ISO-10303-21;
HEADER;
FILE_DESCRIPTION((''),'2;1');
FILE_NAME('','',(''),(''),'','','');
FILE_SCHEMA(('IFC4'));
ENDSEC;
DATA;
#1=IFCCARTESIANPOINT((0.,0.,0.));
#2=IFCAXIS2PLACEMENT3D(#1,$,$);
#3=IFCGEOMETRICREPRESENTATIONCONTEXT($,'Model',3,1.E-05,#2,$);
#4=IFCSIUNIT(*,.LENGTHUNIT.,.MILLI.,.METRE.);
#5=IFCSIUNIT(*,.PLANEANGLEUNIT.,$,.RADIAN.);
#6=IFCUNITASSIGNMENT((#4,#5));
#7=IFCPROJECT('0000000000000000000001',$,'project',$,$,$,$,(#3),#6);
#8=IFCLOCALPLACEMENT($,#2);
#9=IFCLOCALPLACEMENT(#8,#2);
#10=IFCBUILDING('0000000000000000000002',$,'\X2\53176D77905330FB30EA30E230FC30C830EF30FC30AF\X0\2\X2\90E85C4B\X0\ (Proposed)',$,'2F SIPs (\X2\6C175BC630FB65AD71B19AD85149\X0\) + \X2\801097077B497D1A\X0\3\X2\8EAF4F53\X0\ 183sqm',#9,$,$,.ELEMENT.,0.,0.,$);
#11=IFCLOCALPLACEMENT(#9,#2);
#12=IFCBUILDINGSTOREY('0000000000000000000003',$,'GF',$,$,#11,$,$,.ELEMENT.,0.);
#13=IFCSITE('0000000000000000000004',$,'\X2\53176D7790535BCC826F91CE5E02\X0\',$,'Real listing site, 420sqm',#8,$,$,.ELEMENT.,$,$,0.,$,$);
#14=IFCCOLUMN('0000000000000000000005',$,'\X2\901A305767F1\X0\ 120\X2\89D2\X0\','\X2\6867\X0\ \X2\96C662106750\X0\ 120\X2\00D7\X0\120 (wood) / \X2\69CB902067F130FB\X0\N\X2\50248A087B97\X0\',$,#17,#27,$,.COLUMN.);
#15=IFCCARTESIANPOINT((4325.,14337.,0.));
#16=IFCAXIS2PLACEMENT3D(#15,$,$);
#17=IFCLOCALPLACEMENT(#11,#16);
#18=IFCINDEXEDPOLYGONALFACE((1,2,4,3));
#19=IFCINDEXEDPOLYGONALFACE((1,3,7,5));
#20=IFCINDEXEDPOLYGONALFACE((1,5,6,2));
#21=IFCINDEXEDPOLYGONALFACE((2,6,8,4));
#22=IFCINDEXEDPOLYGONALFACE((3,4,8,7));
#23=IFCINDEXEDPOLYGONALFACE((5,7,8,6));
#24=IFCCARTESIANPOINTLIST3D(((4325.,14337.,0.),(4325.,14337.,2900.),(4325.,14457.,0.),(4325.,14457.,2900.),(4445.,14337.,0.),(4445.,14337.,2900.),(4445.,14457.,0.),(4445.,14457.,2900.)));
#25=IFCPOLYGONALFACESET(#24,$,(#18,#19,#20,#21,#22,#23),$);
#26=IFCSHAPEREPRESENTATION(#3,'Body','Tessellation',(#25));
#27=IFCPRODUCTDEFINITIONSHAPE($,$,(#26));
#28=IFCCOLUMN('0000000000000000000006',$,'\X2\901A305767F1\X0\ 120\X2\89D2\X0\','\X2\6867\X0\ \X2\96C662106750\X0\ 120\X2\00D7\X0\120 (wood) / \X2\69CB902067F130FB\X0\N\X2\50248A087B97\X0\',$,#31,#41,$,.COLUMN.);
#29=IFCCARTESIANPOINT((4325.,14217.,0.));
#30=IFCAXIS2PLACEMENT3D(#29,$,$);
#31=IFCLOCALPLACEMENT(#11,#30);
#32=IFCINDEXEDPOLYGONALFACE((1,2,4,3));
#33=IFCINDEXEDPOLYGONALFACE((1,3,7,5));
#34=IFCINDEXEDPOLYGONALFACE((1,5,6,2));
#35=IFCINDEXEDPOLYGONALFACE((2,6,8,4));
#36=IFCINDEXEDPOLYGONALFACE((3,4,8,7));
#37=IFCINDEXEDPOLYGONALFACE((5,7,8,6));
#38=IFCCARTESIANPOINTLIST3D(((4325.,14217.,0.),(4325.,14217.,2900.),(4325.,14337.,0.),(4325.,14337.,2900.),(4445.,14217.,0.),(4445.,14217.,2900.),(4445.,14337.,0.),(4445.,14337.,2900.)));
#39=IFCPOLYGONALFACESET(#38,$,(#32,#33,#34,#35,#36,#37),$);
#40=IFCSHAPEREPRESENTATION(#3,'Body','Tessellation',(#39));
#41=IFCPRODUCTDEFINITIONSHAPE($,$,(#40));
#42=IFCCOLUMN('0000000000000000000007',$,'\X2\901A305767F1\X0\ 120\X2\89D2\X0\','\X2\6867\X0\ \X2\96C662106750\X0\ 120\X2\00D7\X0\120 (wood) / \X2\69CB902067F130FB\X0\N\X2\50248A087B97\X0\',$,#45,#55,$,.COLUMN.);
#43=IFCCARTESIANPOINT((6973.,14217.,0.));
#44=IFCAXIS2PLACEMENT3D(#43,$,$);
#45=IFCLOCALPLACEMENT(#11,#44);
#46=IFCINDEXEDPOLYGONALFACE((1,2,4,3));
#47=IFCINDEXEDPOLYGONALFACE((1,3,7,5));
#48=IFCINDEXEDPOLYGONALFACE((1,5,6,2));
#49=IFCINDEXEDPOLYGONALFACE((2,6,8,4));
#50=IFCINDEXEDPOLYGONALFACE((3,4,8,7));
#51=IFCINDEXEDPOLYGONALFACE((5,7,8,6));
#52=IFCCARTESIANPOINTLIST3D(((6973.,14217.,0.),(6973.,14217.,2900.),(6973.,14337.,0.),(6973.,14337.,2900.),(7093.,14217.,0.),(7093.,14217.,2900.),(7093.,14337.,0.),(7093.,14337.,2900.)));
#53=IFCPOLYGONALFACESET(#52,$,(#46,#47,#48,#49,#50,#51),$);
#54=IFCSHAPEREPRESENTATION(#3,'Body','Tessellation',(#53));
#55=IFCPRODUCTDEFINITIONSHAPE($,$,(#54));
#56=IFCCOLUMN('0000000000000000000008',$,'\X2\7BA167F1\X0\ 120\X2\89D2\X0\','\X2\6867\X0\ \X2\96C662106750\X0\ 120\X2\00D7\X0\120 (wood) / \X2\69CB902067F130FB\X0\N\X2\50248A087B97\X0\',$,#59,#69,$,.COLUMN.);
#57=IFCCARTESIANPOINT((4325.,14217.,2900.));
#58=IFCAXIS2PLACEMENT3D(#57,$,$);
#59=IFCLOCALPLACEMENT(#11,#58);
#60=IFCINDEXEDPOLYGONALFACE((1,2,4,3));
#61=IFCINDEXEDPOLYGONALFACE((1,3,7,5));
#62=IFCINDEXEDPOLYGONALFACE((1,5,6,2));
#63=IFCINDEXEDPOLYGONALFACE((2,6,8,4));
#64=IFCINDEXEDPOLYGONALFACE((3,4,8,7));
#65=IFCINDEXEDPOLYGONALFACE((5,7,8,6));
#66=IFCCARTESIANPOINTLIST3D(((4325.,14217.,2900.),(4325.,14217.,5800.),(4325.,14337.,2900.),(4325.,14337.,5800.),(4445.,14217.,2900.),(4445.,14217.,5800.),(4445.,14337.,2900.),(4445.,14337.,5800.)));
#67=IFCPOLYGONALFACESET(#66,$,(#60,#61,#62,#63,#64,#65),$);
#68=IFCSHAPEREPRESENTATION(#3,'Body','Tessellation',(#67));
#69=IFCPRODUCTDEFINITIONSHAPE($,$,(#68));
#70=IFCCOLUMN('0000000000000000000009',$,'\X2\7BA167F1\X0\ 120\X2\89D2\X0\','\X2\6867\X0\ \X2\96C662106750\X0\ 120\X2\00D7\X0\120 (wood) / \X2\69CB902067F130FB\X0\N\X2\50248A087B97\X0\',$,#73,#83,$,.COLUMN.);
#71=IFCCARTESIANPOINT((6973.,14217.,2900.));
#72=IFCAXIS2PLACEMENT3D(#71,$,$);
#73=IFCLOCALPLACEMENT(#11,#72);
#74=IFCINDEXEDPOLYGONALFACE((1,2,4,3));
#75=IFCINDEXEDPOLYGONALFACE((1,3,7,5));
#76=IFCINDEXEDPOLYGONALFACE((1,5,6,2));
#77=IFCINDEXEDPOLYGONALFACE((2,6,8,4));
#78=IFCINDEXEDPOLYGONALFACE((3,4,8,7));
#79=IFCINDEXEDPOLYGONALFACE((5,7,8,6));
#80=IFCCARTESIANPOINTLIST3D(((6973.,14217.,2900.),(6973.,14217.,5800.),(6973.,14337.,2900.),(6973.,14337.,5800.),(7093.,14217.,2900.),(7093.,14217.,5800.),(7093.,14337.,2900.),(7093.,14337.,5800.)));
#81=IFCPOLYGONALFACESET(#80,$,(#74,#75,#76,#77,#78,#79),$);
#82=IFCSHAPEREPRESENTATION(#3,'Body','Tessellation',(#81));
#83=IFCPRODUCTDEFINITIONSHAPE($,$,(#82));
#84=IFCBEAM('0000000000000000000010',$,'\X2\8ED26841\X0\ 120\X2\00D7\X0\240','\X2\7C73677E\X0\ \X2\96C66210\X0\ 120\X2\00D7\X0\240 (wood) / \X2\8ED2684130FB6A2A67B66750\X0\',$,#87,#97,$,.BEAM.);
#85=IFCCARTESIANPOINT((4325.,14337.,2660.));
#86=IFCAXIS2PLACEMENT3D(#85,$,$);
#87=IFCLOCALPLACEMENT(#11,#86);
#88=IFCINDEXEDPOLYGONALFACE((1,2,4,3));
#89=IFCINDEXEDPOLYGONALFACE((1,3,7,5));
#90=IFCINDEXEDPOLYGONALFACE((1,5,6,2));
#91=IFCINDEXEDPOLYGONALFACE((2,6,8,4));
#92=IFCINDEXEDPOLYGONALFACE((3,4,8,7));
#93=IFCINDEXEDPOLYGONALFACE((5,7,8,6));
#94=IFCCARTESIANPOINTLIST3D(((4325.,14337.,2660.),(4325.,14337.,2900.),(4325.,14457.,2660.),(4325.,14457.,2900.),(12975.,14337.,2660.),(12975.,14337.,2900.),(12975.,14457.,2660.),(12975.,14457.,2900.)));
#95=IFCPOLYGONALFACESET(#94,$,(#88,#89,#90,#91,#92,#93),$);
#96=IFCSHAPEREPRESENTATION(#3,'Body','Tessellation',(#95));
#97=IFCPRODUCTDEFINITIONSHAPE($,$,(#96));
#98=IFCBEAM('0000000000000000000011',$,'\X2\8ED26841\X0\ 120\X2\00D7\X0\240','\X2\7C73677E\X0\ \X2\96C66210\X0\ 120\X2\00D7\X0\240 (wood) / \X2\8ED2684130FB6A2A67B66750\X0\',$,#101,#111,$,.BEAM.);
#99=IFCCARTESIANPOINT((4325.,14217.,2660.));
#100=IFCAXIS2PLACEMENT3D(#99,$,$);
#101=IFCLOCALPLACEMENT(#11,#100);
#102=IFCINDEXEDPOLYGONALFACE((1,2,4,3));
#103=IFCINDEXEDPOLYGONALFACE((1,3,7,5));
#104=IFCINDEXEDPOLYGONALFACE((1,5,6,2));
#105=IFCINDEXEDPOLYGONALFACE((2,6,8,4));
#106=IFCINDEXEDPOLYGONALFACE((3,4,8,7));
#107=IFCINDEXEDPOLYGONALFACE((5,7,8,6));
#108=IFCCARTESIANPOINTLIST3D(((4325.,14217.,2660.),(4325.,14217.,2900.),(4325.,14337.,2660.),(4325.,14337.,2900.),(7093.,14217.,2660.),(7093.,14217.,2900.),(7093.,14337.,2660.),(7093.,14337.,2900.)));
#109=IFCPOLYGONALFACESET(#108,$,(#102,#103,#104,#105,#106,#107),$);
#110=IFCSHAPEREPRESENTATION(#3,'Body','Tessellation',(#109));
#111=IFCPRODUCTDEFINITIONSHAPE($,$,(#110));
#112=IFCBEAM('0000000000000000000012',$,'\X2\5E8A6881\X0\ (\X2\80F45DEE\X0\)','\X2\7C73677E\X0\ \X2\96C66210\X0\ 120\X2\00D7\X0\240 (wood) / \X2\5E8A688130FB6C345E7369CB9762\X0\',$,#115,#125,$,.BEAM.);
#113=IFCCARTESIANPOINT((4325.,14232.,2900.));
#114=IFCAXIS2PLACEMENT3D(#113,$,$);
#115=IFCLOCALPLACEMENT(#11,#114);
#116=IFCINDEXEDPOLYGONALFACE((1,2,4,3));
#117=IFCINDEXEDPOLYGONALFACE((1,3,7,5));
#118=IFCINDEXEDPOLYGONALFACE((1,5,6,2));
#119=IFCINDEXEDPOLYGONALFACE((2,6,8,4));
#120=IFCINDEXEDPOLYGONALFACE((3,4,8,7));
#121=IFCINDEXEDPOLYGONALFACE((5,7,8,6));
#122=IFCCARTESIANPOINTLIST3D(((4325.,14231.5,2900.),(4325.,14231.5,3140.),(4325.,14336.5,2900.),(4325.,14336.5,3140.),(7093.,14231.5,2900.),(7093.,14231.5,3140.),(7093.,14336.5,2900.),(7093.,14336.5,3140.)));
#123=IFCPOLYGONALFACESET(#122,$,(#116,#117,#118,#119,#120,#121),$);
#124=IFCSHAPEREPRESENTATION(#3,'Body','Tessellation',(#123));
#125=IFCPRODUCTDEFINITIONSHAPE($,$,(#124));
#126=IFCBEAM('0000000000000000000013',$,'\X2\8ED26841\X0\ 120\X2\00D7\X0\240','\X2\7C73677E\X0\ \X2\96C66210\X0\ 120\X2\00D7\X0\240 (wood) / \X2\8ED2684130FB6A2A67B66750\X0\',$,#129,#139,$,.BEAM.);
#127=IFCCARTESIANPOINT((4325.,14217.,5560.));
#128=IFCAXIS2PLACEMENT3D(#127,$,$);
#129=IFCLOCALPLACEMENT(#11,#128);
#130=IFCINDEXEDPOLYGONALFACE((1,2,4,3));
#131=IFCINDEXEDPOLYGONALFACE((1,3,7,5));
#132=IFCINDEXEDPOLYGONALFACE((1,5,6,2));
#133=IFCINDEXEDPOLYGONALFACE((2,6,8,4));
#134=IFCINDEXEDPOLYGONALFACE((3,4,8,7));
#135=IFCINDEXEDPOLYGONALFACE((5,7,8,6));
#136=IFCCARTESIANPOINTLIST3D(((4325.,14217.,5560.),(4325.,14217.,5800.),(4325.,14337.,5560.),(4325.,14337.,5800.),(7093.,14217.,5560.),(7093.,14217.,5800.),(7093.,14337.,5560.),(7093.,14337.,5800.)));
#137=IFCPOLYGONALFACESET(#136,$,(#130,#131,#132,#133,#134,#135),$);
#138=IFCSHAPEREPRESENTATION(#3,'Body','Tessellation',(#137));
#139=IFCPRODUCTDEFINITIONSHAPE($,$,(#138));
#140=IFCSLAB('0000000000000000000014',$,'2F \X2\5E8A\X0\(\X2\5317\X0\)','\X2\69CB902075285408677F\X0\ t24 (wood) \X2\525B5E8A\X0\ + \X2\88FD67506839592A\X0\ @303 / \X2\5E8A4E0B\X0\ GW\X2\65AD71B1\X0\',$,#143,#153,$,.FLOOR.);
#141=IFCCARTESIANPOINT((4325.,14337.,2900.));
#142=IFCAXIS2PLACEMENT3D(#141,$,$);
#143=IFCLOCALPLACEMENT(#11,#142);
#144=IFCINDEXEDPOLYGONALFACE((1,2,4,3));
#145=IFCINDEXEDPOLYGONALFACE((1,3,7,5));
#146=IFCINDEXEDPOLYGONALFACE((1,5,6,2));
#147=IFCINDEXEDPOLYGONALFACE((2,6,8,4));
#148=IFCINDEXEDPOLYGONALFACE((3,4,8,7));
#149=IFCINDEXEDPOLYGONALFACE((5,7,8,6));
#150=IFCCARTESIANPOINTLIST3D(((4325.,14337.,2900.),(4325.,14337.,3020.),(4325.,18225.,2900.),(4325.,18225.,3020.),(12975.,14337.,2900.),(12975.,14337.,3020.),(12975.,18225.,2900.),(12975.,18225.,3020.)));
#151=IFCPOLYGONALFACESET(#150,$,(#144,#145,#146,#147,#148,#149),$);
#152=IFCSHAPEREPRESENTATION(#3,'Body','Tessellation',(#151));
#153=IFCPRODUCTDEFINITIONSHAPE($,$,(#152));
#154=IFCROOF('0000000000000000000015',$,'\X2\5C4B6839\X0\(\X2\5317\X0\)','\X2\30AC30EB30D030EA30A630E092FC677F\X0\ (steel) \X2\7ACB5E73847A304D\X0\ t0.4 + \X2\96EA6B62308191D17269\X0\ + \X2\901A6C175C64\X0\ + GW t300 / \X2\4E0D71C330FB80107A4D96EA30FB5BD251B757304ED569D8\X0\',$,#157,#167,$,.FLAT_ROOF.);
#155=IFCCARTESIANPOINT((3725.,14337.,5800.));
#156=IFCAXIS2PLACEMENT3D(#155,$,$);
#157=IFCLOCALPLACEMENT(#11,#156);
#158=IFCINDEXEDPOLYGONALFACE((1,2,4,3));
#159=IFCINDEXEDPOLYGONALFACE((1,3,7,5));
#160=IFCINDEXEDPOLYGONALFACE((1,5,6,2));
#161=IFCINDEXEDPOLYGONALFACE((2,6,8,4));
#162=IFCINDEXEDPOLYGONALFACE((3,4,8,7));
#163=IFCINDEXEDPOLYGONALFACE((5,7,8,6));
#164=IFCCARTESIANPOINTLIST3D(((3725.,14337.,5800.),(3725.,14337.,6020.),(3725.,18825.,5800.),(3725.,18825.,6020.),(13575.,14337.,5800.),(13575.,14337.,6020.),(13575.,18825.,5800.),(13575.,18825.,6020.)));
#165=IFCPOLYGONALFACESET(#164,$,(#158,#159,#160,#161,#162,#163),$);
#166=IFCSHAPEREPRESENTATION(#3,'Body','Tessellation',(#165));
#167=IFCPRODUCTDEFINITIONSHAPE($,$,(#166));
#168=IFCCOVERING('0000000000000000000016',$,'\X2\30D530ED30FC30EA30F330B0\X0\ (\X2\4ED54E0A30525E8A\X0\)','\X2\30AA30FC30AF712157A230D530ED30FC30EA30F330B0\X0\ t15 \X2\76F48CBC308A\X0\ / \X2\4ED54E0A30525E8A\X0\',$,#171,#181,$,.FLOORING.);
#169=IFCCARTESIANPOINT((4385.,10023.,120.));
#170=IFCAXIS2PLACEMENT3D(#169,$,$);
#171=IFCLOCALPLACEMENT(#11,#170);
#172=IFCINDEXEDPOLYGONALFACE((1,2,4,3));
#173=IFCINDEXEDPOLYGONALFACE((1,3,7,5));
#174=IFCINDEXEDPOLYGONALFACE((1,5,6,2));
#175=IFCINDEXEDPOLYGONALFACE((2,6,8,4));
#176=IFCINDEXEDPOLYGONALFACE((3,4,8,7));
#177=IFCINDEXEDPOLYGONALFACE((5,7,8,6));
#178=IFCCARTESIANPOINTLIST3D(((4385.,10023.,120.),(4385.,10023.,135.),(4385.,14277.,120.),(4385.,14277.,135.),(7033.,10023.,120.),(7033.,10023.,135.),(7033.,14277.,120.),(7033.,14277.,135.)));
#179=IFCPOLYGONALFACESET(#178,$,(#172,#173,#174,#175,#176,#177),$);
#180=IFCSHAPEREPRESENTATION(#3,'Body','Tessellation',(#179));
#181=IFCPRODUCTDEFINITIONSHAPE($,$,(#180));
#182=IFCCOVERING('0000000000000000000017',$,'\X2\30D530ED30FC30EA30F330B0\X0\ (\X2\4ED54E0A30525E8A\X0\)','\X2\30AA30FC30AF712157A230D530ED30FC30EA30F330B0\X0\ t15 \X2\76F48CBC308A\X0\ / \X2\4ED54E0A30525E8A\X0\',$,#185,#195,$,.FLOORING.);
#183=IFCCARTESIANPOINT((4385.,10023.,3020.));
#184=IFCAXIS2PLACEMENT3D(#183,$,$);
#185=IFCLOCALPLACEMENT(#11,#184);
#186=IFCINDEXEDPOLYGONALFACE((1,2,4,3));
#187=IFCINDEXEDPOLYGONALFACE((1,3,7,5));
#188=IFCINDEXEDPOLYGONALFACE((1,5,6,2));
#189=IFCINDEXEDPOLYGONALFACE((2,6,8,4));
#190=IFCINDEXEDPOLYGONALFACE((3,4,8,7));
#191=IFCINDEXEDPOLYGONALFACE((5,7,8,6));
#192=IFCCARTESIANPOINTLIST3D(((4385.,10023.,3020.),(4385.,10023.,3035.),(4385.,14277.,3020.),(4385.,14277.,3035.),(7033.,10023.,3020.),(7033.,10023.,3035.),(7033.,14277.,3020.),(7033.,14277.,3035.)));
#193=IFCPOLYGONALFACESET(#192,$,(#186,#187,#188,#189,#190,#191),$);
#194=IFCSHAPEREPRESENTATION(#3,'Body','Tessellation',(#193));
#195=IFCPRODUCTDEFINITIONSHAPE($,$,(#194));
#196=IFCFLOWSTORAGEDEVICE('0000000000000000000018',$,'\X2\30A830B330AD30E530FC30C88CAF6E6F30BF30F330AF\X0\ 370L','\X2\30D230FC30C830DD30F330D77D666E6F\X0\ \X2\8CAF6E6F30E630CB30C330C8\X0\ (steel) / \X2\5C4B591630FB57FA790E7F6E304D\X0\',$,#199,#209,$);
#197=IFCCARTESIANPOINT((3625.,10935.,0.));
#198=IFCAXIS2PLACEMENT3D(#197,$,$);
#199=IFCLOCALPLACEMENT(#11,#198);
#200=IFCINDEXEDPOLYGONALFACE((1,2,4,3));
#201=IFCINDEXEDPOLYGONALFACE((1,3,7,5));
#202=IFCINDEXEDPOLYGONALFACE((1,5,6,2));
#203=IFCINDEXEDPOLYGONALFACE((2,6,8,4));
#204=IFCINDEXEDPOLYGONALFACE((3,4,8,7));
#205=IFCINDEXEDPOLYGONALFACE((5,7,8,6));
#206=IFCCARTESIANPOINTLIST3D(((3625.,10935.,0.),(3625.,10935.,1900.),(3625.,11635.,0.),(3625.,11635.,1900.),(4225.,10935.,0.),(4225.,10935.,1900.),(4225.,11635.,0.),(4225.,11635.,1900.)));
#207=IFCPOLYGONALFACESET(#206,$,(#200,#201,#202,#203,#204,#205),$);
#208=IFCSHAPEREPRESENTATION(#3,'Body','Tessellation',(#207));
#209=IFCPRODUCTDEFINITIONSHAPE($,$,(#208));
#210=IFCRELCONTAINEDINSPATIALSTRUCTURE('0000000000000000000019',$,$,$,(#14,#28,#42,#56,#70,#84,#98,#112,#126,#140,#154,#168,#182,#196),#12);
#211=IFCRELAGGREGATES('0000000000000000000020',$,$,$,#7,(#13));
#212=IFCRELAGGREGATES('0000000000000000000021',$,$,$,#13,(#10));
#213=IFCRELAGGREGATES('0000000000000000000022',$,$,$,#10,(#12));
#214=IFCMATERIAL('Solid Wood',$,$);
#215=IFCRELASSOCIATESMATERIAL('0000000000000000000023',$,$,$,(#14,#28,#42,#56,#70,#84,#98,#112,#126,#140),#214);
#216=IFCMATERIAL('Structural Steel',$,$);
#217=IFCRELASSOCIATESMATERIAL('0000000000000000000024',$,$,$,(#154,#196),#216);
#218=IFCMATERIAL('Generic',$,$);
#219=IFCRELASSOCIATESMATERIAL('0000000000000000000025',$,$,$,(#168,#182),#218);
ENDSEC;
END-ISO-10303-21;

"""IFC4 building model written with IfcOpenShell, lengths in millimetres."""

from ifc_helpers import new_model, si_unit, frame, frame_2d, origin, place, context, project, spatial, rectangle, extrude, material, element, save


model = new_model("IFC4")

# Units and contexts
model_context = context("Model", 3, precision=1e-05, world=origin())
ifc_project = project(units=[si_unit("LENGTHUNIT", "METRE", prefix="MILLI"), si_unit("PLANEANGLEUNIT", "RADIAN")], contexts=[model_context])

# Site, building, storey
site_placement = place(None, origin())
site = spatial("IfcSite", under=ifc_project, at=site_placement, Name="北海道富良野市", ObjectType="Real listing site, 420sqm", CompositionType="ELEMENT", RefElevation=0.0)
building_placement = place(site_placement, origin())
building = spatial("IfcBuilding", under=site, at=building_placement, Name="北海道・リモートワーク2部屋 (Proposed)", ObjectType="2F SIPs (気密・断熱高光) + 耐震等級3躯体 183sqm", CompositionType="ELEMENT", ElevationOfRefHeight=0.0, ElevationOfTerrain=0.0)
storey_placement = place(building_placement, origin())
storey = spatial("IfcBuildingStorey", under=building, at=storey_placement, Name="GF", CompositionType="ELEMENT", Elevation=0.0)

# Columns
ifc_material_1 = material(Name="Solid Wood")
column_1_placement = place(storey_placement, frame((4325.0, 14337.0, 0.0)))
element("IfcColumn", 1, at=column_1_placement, inside=storey, material=ifc_material_1, Name="通し柱 120角", Description="桧 集成材 120×120 (wood) / 構造柱・N値計算", PredefinedType="COLUMN", context=model_context, shape_type="SweptSolid", body=[
    extrude(rectangle(XDim=120.0, YDim=120.0, at=frame_2d((60.0, 60.0))), frame((4325.0, 14337.0, 0.0)), (0.0, 0.0, 1.0), 2900.0),
])
column_2_placement = place(storey_placement, frame((4325.0, 14217.0, 0.0)))
element("IfcColumn", 2, at=column_2_placement, inside=storey, material=ifc_material_1, Name="通し柱 120角", Description="桧 集成材 120×120 (wood) / 構造柱・N値計算", PredefinedType="COLUMN", context=model_context, shape_type="SweptSolid", body=[
    extrude(rectangle(XDim=120.0, YDim=120.0, at=frame_2d((60.0, 60.0))), frame((4325.0, 14217.0, 0.0)), (0.0, 0.0, 1.0), 2900.0),
])
column_3_placement = place(storey_placement, frame((6973.0, 14217.0, 0.0)))
element("IfcColumn", 3, at=column_3_placement, inside=storey, material=ifc_material_1, Name="通し柱 120角", Description="桧 集成材 120×120 (wood) / 構造柱・N値計算", PredefinedType="COLUMN", context=model_context, shape_type="SweptSolid", body=[
    extrude(rectangle(XDim=120.0, YDim=120.0, at=frame_2d((60.0, 60.0))), frame((6973.0, 14217.0, 0.0)), (0.0, 0.0, 1.0), 2900.0),
])
column_4_placement = place(storey_placement, frame((4325.0, 14217.0, 2900.0)))
element("IfcColumn", 4, at=column_4_placement, inside=storey, material=ifc_material_1, Name="管柱 120角", Description="桧 集成材 120×120 (wood) / 構造柱・N値計算", PredefinedType="COLUMN", context=model_context, shape_type="SweptSolid", body=[
    extrude(rectangle(XDim=120.0, YDim=120.0, at=frame_2d((60.0, 60.0))), frame((4325.0, 14217.0, 2900.0)), (0.0, 0.0, 1.0), 2900.0),
])
column_5_placement = place(storey_placement, frame((6973.0, 14217.0, 2900.0)))
element("IfcColumn", 5, at=column_5_placement, inside=storey, material=ifc_material_1, Name="管柱 120角", Description="桧 集成材 120×120 (wood) / 構造柱・N値計算", PredefinedType="COLUMN", context=model_context, shape_type="SweptSolid", body=[
    extrude(rectangle(XDim=120.0, YDim=120.0, at=frame_2d((60.0, 60.0))), frame((6973.0, 14217.0, 2900.0)), (0.0, 0.0, 1.0), 2900.0),
])

# Beams
beam_1_placement = place(storey_placement, frame((4325.0, 14337.0, 2660.0)))
element("IfcBeam", 6, at=beam_1_placement, inside=storey, material=ifc_material_1, Name="軒桁 120×240", Description="米松 集成 120×240 (wood) / 軒桁・横架材", PredefinedType="BEAM", context=model_context, shape_type="SweptSolid", body=[
    extrude(rectangle(XDim=8650.0, YDim=120.0, at=frame_2d((4325.0, 60.0))), frame((4325.0, 14337.0, 2660.0)), (0.0, 0.0, 1.0), 240.0),
])
beam_2_placement = place(storey_placement, frame((4325.0, 14217.0, 2660.0)))
element("IfcBeam", 7, at=beam_2_placement, inside=storey, material=ifc_material_1, Name="軒桁 120×240", Description="米松 集成 120×240 (wood) / 軒桁・横架材", PredefinedType="BEAM", context=model_context, shape_type="SweptSolid", body=[
    extrude(rectangle(XDim=2768.0, YDim=120.0, at=frame_2d((1384.0, 60.0))), frame((4325.0, 14217.0, 2660.0)), (0.0, 0.0, 1.0), 240.0),
])
beam_3_placement = place(storey_placement, frame((4325.0, 14232.0, 2900.0)))
element("IfcBeam", 8, at=beam_3_placement, inside=storey, material=ifc_material_1, Name="床梁 (胴差)", Description="米松 集成 120×240 (wood) / 床梁・水平構面", PredefinedType="BEAM", context=model_context, shape_type="SweptSolid", body=[
    extrude(rectangle(XDim=2768.0, YDim=105.0, at=frame_2d((1384.0, 52.0))), frame((4325.0, 14232.0, 2900.0)), (0.0, 0.0, 1.0), 240.0),
])
beam_4_placement = place(storey_placement, frame((4325.0, 14217.0, 5560.0)))
element("IfcBeam", 9, at=beam_4_placement, inside=storey, material=ifc_material_1, Name="軒桁 120×240", Description="米松 集成 120×240 (wood) / 軒桁・横架材", PredefinedType="BEAM", context=model_context, shape_type="SweptSolid", body=[
    extrude(rectangle(XDim=2768.0, YDim=120.0, at=frame_2d((1384.0, 60.0))), frame((4325.0, 14217.0, 5560.0)), (0.0, 0.0, 1.0), 240.0),
])

# Slab
slab_1_placement = place(storey_placement, frame((4325.0, 14337.0, 2900.0)))
element("IfcSlab", 10, at=slab_1_placement, inside=storey, material=ifc_material_1, Name="2F 床(北)", Description="構造用合板 t24 (wood) 剛床 + 製材根太 @303 / 床下 GW断熱", PredefinedType="FLOOR", context=model_context, shape_type="SweptSolid", body=[
    extrude(rectangle(XDim=8650.0, YDim=3888.0, at=frame_2d((4325.0, 1944.0))), frame((4325.0, 14337.0, 2900.0)), (0.0, 0.0, 1.0), 120.0),
])

# Roof
ifc_material_2 = material(Name="Structural Steel")
for number, where, name in (
    (11, (3725.0, 14337.0, 5800.0), "屋根(北)"),
):
    element("IfcRoof", number, at=place(storey_placement, frame(where)), inside=storey, material=ifc_material_2, Name=name, Description="ガルバリウム鋼板 (steel) 立平葺き t0.4 + 雪止め金物 + 通気層 + GW t300 / 不燃・耐積雪・寒冷地仕様", PredefinedType="FLAT_ROOF", context=model_context, shape_type="SweptSolid", body=[
        extrude(rectangle(XDim=9850.0, YDim=4488.0, at=frame_2d((4925.0, 2244.0))), frame((3725.0, 14337.0, 5800.0)), (0.0, 0.0, 1.0), 220.0),
    ])

# Coverings
ifc_material_3 = material(Name="Generic")
covering_1_placement = place(storey_placement, frame((4385.0, 10023.0, 120.0)))
element("IfcCovering", 12, at=covering_1_placement, inside=storey, material=ifc_material_3, Name="フローリング (仕上げ床)", Description="オーク無垢フローリング t15 直貼り / 仕上げ床", PredefinedType="FLOORING", context=model_context, shape_type="SweptSolid", body=[
    extrude(rectangle(XDim=2648.0, YDim=4254.0, at=frame_2d((1324.0, 2127.0))), frame((4385.0, 10023.0, 120.0)), (0.0, 0.0, 1.0), 15.0),
])
covering_2_placement = place(storey_placement, frame((4385.0, 10023.0, 3020.0)))
element("IfcCovering", 13, at=covering_2_placement, inside=storey, material=ifc_material_3, Name="フローリング (仕上げ床)", Description="オーク無垢フローリング t15 直貼り / 仕上げ床", PredefinedType="FLOORING", context=model_context, shape_type="SweptSolid", body=[
    extrude(rectangle(XDim=2648.0, YDim=4254.0, at=frame_2d((1324.0, 2127.0))), frame((4385.0, 10023.0, 3020.0)), (0.0, 0.0, 1.0), 15.0),
])

# Flow storage device
flow_storage_device_placement = place(storey_placement, frame((3625.0, 10935.0, 0.0)))
element("IfcFlowStorageDevice", 14, at=flow_storage_device_placement, inside=storey, material=ifc_material_2, Name="エコキュート貯湯タンク 370L", Description="ヒートポンプ給湯 貯湯ユニット (steel) / 屋外・基礎置き", context=model_context, shape_type="SweptSolid", body=[
    extrude(rectangle(XDim=600.0, YDim=700.0, at=frame_2d((300.0, 350.0))), frame((3625.0, 10935.0, 0.0)), (0.0, 0.0, 1.0), 1900.0),
])

save(model, "model.ifc")
